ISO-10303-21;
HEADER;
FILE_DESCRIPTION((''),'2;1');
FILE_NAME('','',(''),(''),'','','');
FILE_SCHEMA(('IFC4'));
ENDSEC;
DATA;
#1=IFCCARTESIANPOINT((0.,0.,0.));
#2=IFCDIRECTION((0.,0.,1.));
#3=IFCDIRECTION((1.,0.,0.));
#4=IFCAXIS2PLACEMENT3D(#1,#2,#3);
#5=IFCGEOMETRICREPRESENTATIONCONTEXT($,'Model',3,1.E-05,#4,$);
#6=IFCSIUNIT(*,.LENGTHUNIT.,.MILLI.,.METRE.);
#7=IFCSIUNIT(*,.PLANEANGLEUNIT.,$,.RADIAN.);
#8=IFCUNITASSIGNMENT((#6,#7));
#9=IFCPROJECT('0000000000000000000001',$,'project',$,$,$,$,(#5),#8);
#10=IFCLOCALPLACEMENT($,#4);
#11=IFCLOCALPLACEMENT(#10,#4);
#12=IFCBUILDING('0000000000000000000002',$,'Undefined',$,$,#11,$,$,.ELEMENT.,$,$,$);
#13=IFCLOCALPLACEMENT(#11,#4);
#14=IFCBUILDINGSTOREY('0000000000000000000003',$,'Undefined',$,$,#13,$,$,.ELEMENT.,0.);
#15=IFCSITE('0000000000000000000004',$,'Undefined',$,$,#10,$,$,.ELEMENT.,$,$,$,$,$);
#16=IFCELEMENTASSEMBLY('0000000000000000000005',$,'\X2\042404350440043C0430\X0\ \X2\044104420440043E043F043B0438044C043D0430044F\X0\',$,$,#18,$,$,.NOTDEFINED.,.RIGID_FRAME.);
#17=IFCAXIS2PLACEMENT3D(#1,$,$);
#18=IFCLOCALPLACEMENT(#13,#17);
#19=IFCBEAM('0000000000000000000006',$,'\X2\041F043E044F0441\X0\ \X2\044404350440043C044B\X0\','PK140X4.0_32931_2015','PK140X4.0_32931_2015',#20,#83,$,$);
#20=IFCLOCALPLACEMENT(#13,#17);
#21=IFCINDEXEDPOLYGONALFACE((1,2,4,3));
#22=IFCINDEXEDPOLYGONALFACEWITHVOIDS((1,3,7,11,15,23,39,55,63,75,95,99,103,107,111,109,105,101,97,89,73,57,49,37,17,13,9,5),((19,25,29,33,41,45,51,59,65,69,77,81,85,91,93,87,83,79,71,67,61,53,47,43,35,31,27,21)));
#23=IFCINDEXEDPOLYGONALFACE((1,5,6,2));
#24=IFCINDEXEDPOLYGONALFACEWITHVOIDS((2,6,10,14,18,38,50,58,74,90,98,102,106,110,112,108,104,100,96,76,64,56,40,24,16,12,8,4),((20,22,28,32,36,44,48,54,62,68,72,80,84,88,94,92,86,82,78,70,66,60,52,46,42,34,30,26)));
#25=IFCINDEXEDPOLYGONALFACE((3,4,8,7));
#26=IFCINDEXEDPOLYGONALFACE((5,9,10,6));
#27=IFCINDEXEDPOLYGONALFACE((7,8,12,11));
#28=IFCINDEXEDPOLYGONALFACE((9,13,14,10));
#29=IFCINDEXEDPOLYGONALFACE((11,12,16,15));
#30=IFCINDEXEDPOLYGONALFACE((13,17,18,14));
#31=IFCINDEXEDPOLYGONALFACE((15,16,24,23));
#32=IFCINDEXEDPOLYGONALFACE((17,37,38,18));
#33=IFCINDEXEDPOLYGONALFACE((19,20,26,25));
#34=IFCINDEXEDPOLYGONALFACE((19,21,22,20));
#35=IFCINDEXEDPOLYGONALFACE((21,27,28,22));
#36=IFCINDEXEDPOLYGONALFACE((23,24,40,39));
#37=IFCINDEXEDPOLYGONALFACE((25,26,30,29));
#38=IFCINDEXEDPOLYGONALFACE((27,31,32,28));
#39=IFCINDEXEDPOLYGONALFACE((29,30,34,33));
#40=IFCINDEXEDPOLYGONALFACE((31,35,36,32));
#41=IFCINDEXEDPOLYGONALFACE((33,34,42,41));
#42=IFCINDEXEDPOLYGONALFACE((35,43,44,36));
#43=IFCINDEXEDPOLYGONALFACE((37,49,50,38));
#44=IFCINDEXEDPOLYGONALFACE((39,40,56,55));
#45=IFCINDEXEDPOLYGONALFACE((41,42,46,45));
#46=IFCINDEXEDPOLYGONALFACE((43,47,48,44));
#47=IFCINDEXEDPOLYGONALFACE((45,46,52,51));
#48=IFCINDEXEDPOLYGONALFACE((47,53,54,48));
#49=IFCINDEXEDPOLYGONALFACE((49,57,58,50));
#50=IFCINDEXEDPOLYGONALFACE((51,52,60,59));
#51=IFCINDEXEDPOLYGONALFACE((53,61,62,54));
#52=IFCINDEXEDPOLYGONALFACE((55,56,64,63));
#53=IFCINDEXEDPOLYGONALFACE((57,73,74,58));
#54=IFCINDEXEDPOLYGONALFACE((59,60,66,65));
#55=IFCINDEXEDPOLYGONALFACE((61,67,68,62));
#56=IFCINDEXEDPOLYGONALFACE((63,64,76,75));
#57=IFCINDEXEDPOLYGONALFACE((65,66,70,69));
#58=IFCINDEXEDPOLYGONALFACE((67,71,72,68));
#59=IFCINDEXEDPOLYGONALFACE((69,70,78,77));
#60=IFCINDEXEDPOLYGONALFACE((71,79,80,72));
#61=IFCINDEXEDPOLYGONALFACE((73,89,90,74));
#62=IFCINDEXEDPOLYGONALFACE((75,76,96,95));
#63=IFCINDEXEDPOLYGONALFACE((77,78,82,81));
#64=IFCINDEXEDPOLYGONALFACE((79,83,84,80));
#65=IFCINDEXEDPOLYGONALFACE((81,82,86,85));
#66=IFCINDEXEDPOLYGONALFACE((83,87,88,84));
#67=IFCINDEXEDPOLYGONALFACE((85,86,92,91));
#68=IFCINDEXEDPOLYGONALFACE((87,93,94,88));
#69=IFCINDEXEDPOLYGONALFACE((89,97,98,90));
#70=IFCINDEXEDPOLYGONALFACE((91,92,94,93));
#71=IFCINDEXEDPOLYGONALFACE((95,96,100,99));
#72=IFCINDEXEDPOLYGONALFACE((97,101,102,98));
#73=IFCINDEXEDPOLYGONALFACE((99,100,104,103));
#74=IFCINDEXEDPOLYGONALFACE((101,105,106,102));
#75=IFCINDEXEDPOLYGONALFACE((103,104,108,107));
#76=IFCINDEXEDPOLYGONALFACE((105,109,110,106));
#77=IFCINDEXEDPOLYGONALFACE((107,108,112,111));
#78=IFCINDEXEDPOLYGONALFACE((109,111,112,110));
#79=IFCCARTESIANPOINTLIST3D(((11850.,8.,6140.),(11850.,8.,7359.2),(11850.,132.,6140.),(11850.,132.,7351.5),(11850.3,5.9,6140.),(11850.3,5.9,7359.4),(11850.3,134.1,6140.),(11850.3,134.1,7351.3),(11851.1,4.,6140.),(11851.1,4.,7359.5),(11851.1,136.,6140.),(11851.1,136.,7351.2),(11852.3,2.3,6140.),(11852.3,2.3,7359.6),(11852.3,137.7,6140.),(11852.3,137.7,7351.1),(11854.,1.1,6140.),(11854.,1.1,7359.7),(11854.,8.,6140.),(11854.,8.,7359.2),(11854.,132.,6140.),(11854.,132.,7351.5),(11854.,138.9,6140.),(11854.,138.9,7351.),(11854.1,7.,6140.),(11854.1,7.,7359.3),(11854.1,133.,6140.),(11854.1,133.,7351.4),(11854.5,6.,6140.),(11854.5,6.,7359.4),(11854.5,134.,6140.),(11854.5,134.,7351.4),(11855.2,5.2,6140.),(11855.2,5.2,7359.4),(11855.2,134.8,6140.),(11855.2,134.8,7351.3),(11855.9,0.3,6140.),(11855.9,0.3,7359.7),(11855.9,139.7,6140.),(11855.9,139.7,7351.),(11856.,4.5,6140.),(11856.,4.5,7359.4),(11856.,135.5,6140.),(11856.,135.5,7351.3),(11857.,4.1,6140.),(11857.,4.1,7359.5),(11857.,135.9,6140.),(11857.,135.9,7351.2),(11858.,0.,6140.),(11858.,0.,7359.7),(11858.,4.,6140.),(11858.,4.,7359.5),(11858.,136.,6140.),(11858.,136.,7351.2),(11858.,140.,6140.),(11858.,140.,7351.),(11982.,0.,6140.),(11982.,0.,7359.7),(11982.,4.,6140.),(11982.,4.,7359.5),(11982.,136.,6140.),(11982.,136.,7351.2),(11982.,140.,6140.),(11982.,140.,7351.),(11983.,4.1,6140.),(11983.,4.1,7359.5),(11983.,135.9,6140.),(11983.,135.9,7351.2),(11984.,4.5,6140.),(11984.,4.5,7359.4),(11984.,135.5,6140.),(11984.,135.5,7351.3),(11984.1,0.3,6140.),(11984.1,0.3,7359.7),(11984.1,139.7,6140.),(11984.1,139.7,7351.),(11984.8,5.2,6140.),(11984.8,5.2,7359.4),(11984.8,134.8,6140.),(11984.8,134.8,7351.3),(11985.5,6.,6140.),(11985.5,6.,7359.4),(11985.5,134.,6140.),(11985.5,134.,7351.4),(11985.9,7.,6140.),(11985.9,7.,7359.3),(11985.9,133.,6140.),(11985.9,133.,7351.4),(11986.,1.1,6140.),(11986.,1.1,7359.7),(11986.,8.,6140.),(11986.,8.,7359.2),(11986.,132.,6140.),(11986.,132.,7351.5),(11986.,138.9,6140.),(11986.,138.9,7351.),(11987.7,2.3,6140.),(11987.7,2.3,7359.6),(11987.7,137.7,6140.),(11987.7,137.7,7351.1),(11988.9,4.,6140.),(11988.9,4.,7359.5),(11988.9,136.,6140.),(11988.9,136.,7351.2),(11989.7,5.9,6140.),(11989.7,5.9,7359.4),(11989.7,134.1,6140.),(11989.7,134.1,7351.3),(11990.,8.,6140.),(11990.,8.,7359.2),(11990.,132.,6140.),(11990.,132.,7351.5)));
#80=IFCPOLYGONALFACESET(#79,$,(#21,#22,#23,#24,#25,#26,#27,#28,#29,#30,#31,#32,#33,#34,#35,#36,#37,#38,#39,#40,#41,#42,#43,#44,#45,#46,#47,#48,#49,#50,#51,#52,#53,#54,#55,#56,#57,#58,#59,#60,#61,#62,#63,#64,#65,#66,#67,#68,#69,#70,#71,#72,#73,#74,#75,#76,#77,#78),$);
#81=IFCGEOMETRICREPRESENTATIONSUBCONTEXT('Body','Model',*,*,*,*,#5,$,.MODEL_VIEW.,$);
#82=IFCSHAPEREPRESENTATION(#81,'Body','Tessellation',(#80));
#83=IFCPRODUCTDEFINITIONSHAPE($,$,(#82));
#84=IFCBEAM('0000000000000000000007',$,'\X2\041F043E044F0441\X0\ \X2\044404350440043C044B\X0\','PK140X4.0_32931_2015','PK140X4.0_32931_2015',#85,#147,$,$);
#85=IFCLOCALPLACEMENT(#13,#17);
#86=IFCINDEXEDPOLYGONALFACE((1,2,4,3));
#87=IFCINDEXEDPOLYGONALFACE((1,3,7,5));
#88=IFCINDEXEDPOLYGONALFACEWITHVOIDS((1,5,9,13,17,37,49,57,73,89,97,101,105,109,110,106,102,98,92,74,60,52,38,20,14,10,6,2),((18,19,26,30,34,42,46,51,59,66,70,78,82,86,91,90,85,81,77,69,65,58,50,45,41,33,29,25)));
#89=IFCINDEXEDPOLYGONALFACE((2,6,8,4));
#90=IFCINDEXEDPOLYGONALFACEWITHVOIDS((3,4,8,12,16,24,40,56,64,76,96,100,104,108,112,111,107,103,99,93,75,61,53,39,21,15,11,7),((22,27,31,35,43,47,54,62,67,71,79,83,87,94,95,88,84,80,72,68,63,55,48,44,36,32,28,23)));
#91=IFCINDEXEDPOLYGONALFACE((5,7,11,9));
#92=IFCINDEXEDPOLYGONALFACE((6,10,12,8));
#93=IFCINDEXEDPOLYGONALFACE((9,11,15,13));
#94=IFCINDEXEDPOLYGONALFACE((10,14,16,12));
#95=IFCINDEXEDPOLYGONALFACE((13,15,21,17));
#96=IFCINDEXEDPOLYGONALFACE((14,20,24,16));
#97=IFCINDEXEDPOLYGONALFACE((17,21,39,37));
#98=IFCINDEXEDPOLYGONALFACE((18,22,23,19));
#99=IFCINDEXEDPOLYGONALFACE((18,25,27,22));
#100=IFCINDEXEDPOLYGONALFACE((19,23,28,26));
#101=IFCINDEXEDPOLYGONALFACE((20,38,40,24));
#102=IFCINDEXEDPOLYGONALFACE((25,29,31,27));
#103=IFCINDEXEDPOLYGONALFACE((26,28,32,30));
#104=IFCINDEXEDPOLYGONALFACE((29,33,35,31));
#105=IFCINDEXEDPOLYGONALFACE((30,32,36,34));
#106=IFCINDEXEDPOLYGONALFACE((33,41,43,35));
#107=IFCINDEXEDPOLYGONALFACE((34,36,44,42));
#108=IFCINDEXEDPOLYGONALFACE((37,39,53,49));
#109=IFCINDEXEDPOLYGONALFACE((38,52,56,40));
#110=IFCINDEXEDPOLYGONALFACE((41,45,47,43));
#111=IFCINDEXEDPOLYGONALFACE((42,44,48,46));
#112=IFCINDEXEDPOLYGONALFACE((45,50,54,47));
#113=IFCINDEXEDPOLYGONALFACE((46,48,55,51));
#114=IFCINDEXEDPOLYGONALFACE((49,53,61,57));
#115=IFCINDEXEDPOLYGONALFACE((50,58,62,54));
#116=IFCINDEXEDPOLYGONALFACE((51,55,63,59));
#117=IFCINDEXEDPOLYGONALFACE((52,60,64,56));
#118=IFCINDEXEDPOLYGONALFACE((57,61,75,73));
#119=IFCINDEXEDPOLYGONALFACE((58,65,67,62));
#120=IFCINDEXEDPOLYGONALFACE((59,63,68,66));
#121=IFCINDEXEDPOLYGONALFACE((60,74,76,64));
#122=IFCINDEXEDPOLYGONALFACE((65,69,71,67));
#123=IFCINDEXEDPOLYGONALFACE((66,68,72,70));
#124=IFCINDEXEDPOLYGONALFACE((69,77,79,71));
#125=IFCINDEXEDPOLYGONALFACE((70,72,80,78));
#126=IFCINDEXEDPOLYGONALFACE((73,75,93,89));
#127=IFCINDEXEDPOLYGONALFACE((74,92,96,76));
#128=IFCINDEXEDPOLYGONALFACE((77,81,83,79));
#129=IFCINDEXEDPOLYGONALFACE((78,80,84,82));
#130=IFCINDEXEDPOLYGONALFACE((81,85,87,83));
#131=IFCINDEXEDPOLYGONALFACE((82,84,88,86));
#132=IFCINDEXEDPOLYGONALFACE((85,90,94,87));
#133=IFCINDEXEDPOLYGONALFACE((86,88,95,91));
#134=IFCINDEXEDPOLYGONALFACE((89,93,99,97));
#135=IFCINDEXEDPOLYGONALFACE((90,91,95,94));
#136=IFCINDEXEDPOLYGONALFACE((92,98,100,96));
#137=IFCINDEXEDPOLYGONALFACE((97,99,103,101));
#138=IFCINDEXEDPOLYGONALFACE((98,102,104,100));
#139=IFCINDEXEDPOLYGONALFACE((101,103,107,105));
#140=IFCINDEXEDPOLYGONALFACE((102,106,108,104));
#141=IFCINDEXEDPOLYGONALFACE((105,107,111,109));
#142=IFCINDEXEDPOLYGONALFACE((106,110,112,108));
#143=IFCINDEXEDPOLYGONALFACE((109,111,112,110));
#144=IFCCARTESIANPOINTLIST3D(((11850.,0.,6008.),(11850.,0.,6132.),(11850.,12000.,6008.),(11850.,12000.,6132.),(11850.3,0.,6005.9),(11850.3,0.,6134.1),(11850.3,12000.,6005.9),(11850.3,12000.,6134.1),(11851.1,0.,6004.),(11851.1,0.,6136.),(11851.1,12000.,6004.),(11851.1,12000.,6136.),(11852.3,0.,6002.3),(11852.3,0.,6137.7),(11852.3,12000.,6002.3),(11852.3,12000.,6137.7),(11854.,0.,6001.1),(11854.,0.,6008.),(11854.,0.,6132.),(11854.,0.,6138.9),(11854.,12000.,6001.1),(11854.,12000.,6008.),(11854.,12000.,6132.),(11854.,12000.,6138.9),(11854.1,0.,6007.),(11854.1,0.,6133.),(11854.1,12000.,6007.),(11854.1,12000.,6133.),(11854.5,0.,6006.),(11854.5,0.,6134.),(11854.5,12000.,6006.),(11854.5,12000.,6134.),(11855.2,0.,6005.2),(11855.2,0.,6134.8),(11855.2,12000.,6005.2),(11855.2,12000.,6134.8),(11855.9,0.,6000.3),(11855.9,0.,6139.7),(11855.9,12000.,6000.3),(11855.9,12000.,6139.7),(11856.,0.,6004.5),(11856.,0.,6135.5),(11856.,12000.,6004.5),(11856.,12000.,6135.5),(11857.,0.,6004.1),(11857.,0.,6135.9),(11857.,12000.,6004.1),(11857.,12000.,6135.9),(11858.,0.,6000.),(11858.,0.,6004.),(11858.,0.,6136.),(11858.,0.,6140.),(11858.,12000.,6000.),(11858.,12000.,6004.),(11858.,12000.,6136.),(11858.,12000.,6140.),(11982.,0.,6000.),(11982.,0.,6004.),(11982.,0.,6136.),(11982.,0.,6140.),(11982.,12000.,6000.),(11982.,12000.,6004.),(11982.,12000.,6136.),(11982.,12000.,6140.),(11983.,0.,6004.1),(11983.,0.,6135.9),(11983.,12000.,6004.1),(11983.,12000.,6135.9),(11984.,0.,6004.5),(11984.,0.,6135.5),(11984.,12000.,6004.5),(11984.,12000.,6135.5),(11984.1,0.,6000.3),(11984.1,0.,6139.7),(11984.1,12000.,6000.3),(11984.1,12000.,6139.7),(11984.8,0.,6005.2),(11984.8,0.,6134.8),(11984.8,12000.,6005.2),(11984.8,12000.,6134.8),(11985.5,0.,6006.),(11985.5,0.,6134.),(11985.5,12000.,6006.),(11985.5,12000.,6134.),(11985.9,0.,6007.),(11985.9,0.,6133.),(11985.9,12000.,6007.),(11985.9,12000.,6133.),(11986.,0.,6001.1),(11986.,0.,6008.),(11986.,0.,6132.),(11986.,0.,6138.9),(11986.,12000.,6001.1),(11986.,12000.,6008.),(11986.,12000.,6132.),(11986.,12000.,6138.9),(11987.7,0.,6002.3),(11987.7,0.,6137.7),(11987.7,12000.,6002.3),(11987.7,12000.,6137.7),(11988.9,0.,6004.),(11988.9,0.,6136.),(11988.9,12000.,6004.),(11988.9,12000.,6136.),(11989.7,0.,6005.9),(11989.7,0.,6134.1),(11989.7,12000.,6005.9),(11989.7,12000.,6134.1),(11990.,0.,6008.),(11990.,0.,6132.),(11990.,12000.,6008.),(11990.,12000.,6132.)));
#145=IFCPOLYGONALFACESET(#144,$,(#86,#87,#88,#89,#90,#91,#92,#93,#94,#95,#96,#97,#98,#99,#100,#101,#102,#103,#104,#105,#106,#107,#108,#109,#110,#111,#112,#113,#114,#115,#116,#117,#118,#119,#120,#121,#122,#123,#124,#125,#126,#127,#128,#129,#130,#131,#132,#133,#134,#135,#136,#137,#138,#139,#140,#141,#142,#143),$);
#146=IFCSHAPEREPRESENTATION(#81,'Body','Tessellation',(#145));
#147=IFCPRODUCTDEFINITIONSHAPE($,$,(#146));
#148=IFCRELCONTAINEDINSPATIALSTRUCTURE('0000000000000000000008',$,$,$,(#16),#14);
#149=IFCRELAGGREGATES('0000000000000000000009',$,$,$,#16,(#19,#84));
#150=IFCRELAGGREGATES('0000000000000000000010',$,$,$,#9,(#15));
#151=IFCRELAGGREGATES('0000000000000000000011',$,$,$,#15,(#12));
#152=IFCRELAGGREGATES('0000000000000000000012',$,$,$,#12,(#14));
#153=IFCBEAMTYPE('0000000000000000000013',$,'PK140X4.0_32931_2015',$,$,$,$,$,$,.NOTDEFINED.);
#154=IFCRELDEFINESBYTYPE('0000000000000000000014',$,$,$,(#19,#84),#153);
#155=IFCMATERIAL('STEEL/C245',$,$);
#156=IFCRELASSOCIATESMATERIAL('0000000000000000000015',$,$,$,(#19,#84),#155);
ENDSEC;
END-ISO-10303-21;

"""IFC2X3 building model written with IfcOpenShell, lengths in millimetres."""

from ifc_helpers import new_model, si_unit, frame, origin_with_axes, origin_2d_with_axis, place, context, subcontext, project, spatial, hollow_rectangle, extrude, clip, halfspace, material, type_object, element, aggregate, save


model = new_model("IFC2X3")

# Units and contexts
model_context = context("Model", 3, precision=1e-05, world=origin_with_axes())
body_context = subcontext(model_context, "Body", "Model", "MODEL_VIEW")
ifc_project = project(units=[si_unit("LENGTHUNIT", "METRE", prefix="MILLI"), si_unit("PLANEANGLEUNIT", "RADIAN")], contexts=[model_context])

# Site, building, storey
site_placement = place(None, origin_with_axes())
site = spatial("IfcSite", under=ifc_project, at=site_placement, Name="Undefined", CompositionType="ELEMENT")
building_placement = place(site_placement, origin_with_axes())
building = spatial("IfcBuilding", under=site, at=building_placement, Name="Undefined", CompositionType="ELEMENT")
storey_placement = place(building_placement, origin_with_axes())
storey = spatial("IfcBuildingStorey", under=building, at=storey_placement, Name="Undefined", CompositionType="ELEMENT", Elevation=0.0)

# Shared definitions
ifc_material = material(Name="STEEL/C245")

# Element assembly
assembly_1_placement = place(storey_placement, origin_with_axes())
assembly_1 = element("IfcElementAssembly", 1, at=assembly_1_placement, inside=storey, Name="Ферма строплиьная", AssemblyPlace="NOTDEFINED", PredefinedType="RIGID_FRAME")

# Beams
beam_type_1 = type_object("IfcBeamType", Name="PK140X4.0_32931_2015", PredefinedType="NOTDEFINED")
beam_1_placement = place(assembly_1_placement, frame((11920.0, 70.0, 7359.7), z_axis=(1.0, 0.0, 0.0), x_axis=(0.0, 0.0, -1.0)))
beam_1 = element("IfcBeam", 2, at=beam_1_placement, type_object=beam_type_1, material=ifc_material, Name="Пояс фермы", Description="PK140X4.0_32931_2015", ObjectType="PK140X4.0_32931_2015", context=body_context, shape_type="Clipping", body=[
    clip(extrude(hollow_rectangle(XDim=140.0, YDim=140.0, WallThickness=4.0, InnerFilletRadius=4.0, OuterFilletRadius=8.0, at=origin_2d_with_axis()), frame((1219.7, 0.0, 0.0), z_axis=(-1.0, 0.0, 0.0), x_axis=(0.0, -1.0, 0.0)), (0.0, 0.0, 1.0), 1219.8), halfspace(frame((10.5, 98.4, 0.0), z_axis=(0.998053, -0.062378, 0.0), x_axis=(0.0, 0.0, 1.0)), True)),
])
beam_2_placement = place(assembly_1_placement, frame((11920.0, 0.0, 6070.0), z_axis=(0.0, 0.0, 1.0), x_axis=(0.0, 1.0, 0.0)))
beam_2 = element("IfcBeam", 3, at=beam_2_placement, type_object=beam_type_1, material=ifc_material, Name="Пояс фермы", Description="PK140X4.0_32931_2015", ObjectType="PK140X4.0_32931_2015", context=body_context, shape_type="SweptSolid", body=[
    extrude(hollow_rectangle(XDim=140.0, YDim=140.0, WallThickness=4.0, InnerFilletRadius=4.0, OuterFilletRadius=8.0, at=origin_2d_with_axis()), frame((12000.0, 0.0, 0.0), z_axis=(-1.0, 0.0, 0.0), x_axis=(0.0, -1.0, 0.0)), (0.0, 0.0, 1.0), 12000.0),
])
aggregate(assembly_1, [beam_1, beam_2])

save(model, "model.ifc")
